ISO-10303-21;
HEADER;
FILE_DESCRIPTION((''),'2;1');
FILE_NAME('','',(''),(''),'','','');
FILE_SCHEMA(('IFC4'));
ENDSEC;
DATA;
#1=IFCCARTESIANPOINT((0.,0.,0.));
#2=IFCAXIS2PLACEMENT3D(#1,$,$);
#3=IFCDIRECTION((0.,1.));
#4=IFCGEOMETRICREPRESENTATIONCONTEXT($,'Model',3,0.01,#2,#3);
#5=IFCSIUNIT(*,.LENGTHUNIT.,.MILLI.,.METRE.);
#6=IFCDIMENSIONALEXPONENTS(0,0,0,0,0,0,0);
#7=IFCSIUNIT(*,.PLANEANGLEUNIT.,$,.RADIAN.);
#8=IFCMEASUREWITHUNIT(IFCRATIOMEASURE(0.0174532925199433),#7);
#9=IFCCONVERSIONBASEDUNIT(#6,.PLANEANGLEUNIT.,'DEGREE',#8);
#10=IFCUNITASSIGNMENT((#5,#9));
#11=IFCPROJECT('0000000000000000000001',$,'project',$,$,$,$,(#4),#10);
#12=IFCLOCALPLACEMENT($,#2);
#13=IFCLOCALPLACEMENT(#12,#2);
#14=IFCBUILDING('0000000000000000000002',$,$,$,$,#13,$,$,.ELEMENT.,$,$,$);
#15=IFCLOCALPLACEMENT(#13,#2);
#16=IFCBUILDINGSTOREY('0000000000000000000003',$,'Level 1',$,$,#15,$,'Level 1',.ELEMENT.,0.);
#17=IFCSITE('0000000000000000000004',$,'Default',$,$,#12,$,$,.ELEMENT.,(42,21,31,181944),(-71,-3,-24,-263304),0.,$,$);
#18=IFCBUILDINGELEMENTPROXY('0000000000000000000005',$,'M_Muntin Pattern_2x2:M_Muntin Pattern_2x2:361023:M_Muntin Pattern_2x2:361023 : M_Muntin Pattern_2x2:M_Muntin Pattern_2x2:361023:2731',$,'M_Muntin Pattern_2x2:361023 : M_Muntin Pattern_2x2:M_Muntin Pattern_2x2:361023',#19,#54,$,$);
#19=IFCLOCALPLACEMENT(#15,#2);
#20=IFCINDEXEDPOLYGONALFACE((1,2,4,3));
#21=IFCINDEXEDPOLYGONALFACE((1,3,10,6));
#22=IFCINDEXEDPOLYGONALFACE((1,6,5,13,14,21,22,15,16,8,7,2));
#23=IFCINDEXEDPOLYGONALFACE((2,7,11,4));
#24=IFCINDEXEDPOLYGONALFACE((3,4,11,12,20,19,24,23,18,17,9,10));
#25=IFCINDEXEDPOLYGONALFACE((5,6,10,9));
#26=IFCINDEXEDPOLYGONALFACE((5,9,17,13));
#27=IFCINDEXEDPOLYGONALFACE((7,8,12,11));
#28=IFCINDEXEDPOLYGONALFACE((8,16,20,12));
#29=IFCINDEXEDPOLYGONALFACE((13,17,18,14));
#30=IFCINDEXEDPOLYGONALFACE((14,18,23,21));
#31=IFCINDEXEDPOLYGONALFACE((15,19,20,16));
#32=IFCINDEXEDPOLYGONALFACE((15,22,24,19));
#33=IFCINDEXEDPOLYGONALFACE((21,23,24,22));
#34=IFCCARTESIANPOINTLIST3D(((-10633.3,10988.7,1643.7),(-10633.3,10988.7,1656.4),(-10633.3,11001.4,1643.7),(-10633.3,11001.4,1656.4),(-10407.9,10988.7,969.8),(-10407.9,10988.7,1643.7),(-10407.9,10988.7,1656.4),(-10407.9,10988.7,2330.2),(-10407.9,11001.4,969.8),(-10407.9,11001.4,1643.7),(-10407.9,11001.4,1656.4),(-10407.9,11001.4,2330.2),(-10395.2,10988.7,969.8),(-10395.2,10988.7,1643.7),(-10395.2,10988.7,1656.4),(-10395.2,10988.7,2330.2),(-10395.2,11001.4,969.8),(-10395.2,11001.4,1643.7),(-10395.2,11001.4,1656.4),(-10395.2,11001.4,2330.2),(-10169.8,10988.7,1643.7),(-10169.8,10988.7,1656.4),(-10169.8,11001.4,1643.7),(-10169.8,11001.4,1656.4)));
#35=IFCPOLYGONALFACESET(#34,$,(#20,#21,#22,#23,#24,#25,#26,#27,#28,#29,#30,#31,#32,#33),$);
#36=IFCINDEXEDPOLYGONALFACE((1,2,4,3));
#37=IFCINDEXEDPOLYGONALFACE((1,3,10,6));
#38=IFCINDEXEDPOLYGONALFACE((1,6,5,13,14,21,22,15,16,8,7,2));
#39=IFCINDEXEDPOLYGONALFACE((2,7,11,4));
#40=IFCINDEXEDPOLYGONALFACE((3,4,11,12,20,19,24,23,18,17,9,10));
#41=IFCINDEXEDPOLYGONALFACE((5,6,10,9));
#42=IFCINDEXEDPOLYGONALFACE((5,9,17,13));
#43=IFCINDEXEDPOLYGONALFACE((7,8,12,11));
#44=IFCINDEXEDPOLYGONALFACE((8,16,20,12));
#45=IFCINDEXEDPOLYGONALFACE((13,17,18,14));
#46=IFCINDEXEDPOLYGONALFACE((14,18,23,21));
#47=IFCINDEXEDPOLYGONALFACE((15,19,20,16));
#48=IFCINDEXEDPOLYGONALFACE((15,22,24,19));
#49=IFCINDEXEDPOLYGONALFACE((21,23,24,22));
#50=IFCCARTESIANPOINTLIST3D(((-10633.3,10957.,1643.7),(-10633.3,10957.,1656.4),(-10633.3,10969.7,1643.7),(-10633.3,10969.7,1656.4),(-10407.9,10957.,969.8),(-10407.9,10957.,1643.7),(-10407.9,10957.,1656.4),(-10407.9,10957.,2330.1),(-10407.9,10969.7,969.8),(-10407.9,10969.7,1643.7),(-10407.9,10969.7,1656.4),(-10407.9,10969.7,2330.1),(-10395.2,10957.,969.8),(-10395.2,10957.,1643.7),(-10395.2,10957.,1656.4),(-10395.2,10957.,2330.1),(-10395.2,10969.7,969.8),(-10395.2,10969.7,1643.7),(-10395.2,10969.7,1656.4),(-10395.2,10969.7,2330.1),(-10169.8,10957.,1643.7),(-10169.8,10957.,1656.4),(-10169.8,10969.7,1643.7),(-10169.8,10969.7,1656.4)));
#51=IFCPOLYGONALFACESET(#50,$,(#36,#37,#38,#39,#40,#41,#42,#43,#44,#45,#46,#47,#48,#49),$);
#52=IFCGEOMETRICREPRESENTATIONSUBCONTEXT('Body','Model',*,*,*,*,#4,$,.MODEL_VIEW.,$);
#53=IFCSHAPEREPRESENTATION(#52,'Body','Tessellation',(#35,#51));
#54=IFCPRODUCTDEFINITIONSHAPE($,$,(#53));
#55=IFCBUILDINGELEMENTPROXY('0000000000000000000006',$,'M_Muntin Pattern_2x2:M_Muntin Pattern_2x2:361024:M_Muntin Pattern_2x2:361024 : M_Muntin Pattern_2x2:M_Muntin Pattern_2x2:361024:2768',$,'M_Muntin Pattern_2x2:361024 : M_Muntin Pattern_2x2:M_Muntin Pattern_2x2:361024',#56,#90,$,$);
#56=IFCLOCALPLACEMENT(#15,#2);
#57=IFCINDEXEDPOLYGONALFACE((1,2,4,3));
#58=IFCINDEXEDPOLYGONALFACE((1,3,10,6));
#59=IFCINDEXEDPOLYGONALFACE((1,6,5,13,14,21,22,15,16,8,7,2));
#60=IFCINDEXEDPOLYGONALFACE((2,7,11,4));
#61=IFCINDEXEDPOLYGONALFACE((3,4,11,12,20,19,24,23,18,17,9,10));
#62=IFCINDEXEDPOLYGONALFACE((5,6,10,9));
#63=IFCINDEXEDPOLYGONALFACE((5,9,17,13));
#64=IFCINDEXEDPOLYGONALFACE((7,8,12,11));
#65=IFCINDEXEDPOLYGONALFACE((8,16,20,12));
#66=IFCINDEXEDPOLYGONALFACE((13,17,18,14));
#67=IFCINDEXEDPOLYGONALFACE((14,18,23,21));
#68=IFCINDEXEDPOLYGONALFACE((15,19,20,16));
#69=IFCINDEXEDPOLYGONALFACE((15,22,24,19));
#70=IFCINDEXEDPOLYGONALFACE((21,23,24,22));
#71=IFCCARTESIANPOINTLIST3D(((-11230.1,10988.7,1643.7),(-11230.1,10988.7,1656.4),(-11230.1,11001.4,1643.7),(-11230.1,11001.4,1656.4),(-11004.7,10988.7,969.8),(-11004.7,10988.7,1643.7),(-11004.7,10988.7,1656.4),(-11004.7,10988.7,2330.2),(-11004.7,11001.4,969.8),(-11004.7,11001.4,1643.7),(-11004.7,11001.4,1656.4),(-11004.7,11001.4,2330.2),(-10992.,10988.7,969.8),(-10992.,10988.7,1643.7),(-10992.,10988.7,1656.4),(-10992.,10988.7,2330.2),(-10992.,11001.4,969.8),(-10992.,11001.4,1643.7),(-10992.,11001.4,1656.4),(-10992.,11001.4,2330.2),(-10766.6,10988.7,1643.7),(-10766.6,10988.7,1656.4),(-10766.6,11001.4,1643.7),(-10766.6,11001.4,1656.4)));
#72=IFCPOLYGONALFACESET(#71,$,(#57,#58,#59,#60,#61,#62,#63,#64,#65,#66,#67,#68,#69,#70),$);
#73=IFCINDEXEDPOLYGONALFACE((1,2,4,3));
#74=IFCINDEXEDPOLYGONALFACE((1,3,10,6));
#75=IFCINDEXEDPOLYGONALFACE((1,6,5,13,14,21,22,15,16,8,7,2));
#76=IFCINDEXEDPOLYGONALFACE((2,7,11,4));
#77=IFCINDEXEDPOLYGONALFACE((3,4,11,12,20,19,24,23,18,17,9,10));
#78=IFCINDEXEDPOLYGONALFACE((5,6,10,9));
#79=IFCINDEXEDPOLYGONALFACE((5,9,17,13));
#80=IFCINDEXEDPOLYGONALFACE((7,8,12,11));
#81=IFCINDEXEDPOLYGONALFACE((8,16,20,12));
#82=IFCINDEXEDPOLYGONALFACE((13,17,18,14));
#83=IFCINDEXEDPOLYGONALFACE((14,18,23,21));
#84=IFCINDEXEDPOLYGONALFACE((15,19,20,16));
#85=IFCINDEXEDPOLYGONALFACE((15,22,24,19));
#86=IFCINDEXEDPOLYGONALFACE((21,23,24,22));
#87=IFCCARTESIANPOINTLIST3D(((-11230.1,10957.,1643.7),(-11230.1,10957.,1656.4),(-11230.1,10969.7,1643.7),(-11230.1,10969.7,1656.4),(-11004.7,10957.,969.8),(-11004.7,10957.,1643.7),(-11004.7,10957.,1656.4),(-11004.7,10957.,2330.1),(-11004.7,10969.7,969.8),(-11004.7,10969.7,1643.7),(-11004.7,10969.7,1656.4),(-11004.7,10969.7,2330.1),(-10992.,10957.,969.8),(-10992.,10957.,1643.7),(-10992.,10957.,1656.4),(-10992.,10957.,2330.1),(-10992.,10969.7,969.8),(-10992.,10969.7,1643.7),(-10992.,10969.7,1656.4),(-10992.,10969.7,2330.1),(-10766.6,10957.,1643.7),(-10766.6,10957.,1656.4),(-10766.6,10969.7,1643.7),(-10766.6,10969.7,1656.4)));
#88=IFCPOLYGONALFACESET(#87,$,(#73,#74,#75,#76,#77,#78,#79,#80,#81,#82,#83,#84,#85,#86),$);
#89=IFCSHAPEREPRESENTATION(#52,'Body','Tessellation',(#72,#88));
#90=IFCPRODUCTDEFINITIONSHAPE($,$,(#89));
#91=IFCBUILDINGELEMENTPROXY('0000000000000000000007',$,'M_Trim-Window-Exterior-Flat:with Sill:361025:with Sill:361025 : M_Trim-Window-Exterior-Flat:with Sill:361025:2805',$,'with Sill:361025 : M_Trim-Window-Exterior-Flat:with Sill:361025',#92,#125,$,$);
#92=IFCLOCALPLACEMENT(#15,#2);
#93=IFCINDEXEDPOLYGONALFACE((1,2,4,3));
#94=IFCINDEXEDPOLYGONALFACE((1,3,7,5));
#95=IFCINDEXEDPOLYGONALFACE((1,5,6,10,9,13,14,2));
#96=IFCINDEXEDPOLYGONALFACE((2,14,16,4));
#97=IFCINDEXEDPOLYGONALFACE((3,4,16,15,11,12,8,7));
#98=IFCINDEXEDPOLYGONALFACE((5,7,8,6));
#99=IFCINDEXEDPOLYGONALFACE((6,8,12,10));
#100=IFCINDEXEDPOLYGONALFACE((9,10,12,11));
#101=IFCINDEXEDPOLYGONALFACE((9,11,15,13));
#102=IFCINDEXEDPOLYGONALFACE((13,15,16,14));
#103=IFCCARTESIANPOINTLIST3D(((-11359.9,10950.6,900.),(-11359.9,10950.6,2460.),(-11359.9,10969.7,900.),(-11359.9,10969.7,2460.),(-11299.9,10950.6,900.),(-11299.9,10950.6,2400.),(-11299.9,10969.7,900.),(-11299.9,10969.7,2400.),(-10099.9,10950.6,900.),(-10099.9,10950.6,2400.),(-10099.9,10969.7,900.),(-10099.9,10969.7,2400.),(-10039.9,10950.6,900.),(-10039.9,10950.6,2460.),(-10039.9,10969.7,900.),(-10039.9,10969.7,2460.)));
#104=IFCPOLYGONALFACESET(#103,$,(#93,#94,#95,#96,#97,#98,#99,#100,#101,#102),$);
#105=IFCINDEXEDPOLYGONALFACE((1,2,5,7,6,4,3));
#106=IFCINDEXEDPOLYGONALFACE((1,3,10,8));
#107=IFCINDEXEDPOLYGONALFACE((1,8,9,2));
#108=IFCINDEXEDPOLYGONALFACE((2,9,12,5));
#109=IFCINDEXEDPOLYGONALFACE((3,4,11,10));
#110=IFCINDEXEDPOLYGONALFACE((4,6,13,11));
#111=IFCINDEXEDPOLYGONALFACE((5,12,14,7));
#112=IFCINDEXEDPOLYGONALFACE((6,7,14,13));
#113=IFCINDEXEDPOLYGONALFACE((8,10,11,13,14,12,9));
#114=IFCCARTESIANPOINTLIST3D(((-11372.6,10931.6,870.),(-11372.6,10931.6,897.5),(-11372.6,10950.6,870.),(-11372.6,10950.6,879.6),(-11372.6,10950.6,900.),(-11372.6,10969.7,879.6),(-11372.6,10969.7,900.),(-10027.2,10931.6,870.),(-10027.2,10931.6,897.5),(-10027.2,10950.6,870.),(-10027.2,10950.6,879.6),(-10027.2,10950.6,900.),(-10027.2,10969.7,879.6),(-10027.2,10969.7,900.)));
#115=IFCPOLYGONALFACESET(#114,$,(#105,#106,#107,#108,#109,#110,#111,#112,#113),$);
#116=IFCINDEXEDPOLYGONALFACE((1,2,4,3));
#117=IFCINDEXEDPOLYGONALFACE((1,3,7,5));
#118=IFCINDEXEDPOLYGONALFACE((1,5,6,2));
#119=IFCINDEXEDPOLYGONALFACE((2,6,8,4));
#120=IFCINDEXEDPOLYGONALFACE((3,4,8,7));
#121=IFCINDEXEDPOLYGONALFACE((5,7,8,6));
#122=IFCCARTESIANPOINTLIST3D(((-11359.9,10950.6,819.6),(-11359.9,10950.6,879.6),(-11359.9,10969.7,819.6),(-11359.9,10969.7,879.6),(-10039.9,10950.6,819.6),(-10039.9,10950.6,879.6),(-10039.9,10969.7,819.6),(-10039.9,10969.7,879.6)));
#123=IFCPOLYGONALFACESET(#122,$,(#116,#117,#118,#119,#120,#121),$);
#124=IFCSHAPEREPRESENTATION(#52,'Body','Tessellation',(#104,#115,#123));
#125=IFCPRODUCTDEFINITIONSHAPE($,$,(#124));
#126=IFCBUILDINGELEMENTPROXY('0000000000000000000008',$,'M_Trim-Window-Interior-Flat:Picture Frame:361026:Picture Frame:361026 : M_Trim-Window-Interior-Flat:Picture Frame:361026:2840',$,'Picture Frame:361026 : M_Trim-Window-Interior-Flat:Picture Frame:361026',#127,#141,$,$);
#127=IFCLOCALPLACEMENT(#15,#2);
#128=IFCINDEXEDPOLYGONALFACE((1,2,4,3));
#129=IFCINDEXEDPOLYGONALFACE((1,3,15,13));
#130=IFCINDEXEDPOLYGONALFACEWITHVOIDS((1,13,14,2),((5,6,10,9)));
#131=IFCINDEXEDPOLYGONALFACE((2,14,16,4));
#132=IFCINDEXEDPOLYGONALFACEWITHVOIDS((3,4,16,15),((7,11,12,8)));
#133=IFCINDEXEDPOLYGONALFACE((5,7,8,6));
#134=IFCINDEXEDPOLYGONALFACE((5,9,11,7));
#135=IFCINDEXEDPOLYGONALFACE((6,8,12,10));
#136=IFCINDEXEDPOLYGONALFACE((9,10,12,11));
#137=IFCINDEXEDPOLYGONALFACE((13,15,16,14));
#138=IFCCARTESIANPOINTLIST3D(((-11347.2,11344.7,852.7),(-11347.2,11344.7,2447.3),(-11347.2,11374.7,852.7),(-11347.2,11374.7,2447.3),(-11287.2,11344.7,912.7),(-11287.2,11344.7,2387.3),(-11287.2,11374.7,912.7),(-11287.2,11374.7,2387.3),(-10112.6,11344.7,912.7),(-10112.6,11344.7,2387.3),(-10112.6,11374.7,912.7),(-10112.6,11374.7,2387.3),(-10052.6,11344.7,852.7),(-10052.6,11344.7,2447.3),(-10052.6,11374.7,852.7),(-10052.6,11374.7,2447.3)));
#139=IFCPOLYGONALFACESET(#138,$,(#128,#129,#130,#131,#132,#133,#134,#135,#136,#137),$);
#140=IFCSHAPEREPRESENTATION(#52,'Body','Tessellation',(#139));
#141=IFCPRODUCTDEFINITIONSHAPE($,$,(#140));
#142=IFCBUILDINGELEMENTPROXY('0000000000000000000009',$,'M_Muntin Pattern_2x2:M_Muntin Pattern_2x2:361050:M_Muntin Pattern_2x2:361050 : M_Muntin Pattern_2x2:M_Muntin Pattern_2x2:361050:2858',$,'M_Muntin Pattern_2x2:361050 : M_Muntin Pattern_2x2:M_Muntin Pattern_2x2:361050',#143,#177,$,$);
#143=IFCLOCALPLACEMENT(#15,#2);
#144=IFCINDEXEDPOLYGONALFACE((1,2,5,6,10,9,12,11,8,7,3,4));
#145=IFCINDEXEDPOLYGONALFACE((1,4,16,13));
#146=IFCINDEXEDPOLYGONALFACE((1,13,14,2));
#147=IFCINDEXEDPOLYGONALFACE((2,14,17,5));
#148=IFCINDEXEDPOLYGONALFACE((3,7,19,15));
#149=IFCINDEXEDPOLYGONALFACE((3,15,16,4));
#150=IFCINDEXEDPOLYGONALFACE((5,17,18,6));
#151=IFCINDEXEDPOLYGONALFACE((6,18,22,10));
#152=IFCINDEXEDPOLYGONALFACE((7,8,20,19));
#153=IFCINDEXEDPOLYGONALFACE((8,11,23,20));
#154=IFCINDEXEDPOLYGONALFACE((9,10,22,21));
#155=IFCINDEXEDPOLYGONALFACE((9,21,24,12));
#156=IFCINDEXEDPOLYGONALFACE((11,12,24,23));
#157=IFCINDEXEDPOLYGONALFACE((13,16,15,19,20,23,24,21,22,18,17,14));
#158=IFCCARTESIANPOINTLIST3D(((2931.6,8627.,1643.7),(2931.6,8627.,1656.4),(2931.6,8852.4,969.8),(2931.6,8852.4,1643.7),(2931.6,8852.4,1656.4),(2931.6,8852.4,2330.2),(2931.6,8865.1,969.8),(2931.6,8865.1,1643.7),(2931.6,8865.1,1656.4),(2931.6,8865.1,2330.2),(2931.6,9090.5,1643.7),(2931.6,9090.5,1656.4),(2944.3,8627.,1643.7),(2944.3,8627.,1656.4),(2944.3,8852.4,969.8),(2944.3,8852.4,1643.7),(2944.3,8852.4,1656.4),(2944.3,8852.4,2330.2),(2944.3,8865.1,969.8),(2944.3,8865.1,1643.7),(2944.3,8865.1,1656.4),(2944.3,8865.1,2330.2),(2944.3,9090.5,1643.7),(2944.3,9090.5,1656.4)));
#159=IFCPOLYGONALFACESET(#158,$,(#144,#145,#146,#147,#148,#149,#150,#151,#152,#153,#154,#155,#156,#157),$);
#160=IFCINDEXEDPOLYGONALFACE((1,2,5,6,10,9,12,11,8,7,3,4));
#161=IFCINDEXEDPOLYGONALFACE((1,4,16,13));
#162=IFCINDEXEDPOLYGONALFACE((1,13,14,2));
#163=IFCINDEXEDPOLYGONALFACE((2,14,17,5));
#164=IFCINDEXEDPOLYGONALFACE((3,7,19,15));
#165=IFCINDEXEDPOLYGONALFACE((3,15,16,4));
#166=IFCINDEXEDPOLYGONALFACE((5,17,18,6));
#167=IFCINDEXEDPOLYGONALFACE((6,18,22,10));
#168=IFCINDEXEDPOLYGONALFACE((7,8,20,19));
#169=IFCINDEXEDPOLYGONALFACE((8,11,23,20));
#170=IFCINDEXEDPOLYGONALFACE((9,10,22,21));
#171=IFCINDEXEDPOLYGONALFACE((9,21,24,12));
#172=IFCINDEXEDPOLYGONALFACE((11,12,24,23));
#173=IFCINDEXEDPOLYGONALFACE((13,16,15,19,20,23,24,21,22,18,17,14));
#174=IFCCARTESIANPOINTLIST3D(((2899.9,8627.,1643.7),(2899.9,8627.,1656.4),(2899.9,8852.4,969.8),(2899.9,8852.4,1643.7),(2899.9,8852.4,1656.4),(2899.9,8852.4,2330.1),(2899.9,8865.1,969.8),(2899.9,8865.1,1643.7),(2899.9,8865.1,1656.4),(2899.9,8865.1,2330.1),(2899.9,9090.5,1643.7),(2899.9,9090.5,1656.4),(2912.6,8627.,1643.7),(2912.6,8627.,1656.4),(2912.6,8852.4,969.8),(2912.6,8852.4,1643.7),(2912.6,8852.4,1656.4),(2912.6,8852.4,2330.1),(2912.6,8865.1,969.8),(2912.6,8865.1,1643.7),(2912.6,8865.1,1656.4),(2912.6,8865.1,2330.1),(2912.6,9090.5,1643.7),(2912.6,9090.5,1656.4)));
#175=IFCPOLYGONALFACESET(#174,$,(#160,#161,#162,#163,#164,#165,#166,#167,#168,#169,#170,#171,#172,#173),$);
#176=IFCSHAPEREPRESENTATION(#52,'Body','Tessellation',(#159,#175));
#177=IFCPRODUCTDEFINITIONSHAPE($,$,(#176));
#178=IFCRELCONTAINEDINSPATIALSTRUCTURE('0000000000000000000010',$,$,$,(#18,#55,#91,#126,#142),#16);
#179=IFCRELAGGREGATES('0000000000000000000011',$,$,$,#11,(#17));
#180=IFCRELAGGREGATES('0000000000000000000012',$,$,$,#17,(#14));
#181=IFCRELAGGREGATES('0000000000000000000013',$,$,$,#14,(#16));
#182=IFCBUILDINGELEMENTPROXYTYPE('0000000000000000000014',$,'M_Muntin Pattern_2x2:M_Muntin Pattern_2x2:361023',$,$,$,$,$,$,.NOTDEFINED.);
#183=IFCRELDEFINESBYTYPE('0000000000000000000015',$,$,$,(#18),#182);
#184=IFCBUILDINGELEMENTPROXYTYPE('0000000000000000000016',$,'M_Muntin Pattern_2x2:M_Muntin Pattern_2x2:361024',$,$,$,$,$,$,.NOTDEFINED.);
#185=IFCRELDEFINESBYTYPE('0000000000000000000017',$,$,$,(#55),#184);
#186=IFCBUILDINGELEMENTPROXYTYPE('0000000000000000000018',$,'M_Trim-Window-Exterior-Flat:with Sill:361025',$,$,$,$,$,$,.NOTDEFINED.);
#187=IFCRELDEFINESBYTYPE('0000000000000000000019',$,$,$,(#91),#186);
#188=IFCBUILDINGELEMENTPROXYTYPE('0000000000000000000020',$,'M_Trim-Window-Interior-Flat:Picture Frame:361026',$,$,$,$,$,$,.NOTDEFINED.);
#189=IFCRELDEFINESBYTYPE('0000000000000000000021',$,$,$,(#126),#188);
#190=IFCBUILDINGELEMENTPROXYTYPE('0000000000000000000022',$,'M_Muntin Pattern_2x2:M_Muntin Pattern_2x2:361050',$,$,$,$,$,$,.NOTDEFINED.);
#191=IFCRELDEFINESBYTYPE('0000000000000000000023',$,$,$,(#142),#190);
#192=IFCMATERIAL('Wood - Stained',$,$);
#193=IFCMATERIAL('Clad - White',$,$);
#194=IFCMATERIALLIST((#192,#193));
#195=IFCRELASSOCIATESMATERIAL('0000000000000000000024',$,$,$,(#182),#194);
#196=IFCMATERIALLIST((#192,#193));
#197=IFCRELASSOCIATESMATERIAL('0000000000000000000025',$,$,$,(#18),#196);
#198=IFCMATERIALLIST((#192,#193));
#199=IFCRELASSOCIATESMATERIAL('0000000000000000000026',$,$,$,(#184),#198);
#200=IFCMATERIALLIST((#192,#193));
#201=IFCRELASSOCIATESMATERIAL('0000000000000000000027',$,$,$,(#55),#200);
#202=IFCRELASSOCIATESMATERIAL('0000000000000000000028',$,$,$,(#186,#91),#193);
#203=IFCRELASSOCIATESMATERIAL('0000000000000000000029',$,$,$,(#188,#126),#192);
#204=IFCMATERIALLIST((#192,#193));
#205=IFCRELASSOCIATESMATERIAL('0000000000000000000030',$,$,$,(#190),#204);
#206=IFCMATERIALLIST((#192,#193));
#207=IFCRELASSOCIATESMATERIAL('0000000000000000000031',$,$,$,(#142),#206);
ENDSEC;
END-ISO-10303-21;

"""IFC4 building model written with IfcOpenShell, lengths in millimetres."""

from ifc_helpers import new_model, entity, si_unit, converted_unit, direction, frame, frame_2d, origin, place, context, subcontext, project, spatial, polyline, rectangle, outline, extrude, source, transform, mapped, material, material_list, type_object, type_shapes, element, save


model = new_model("IFC4")

# Units and contexts
model_context = context("Model", 3, precision=0.01, world=origin(), true_north=direction((0.0, 1.0)))
body_context = subcontext(model_context, "Body", "Model", "MODEL_VIEW")
ifc_project = project(units=[si_unit("LENGTHUNIT", "METRE", prefix="MILLI"), converted_unit("PLANEANGLEUNIT", "DEGREE", entity("IfcRatioMeasure", 0.0174532925199433), si_unit("PLANEANGLEUNIT", "RADIAN"), dimensions=[0, 0, 0, 0, 0, 0, 0])], contexts=[model_context])

# Site, building, storey
site_placement = place(None, origin())
site = spatial("IfcSite", under=ifc_project, at=site_placement, Name="Default", CompositionType="ELEMENT", RefLatitude=(42, 21, 31, 181944), RefLongitude=(-71, -3, -24, -263304), RefElevation=0.0)
building_placement = place(site_placement, origin())
building = spatial("IfcBuilding", under=site, at=building_placement, CompositionType="ELEMENT")
storey_placement = place(building_placement, origin())
storey = spatial("IfcBuildingStorey", under=building, at=storey_placement, Name="Level 1", LongName="Level 1", CompositionType="ELEMENT", Elevation=0.0)

# Building element proxies
ifc_material_1 = material(Name="Wood - Stained")
ifc_material_2 = material(Name="Clad - White")
ifc_material_list_1 = material_list([ifc_material_1, ifc_material_2])
ifc_material_list_2 = material_list([ifc_material_1, ifc_material_2])
building_element_proxy_type_1 = type_object("IfcBuildingElementProxyType", Name="M_Muntin Pattern_2x2:M_Muntin Pattern_2x2:361023", PredefinedType="NOTDEFINED", material=ifc_material_list_2)
shared_shape_1 = source(origin(), body_context, "Body", "SweptSolid", [
    extrude(outline(polyline([(-680.2, 6.4), (-680.2, -6.3), (-6.4, -6.3), (-6.4, -231.7), (6.3, -231.7), (6.3, -6.3), (680.2, -6.3), (680.2, 6.4), (6.3, 6.4), (6.3, 231.7), (-6.4, 231.7), (-6.4, 6.4), (-680.2, 6.4)])), frame((-10401.5, 10988.7, 1650.0), z_axis=(0.0, -1.0, 0.0), x_axis=(0.0, 0.0, -1.0)), (0.0, 0.0, -1.0), 12.7),
    extrude(outline(polyline([(-680.1, 6.4), (-680.1, -6.3), (-6.4, -6.3), (-6.4, -231.7), (6.3, -231.7), (6.3, -6.3), (680.2, -6.3), (680.2, 6.4), (6.3, 6.4), (6.3, 231.7), (-6.4, 231.7), (-6.4, 6.4), (-680.1, 6.4)])), frame((-10401.5, 10957.0, 1650.0), z_axis=(0.0, -1.0, 0.0), x_axis=(0.0, 0.0, -1.0)), (0.0, 0.0, -1.0), 12.7),
])
type_shapes(building_element_proxy_type_1, [shared_shape_1])
proxy_1_placement = place(storey_placement, origin())
element("IfcBuildingElementProxy", 1, at=proxy_1_placement, inside=storey, type_object=building_element_proxy_type_1, material=ifc_material_list_1, Name="M_Muntin Pattern_2x2:M_Muntin Pattern_2x2:361023:M_Muntin Pattern_2x2:361023 : M_Muntin Pattern_2x2:M_Muntin Pattern_2x2:361023:2731", ObjectType="M_Muntin Pattern_2x2:361023 : M_Muntin Pattern_2x2:M_Muntin Pattern_2x2:361023", context=body_context, shape_type="MappedRepresentation", body=[
    mapped(shared_shape_1, transform((0.0, 0.0, 0.0), scale=1.0)),
])
ifc_material_list_3 = material_list([ifc_material_1, ifc_material_2])
ifc_material_list_4 = material_list([ifc_material_1, ifc_material_2])
building_element_proxy_type_2 = type_object("IfcBuildingElementProxyType", Name="M_Muntin Pattern_2x2:M_Muntin Pattern_2x2:361024", PredefinedType="NOTDEFINED", material=ifc_material_list_4)
shared_shape_2 = source(origin(), body_context, "Body", "SweptSolid", [
    extrude(outline(polyline([(-6.4, -680.1), (6.3, -680.1), (6.3, -6.4), (231.7, -6.4), (231.7, 6.3), (6.3, 6.3), (6.3, 680.2), (-6.4, 680.2), (-6.4, 6.3), (-231.7, 6.3), (-231.7, -6.4), (-6.4, -6.4), (-6.4, -680.1)])), frame((-10998.4, 10988.7, 1650.0), z_axis=(0.0, 1.0, 0.0), x_axis=(1.0, 0.0, 0.0)), (0.0, 0.0, 1.0), 12.7),
    extrude(outline(polyline([(-6.4, -680.1), (6.3, -680.1), (6.3, -6.4), (231.7, -6.4), (231.7, 6.3), (6.3, 6.3), (6.3, 680.2), (-6.4, 680.2), (-6.4, 6.3), (-231.7, 6.3), (-231.7, -6.4), (-6.4, -6.4), (-6.4, -680.1)])), frame((-10998.4, 10957.0, 1650.0), z_axis=(0.0, 1.0, 0.0), x_axis=(1.0, 0.0, 0.0)), (0.0, 0.0, 1.0), 12.7),
])
type_shapes(building_element_proxy_type_2, [shared_shape_2])
proxy_2_placement = place(storey_placement, origin())
element("IfcBuildingElementProxy", 2, at=proxy_2_placement, inside=storey, type_object=building_element_proxy_type_2, material=ifc_material_list_3, Name="M_Muntin Pattern_2x2:M_Muntin Pattern_2x2:361024:M_Muntin Pattern_2x2:361024 : M_Muntin Pattern_2x2:M_Muntin Pattern_2x2:361024:2768", ObjectType="M_Muntin Pattern_2x2:361024 : M_Muntin Pattern_2x2:M_Muntin Pattern_2x2:361024", context=body_context, shape_type="MappedRepresentation", body=[
    mapped(shared_shape_2, transform((0.0, 0.0, 0.0), scale=1.0)),
])
building_element_proxy_type_3 = type_object("IfcBuildingElementProxyType", Name="M_Trim-Window-Exterior-Flat:with Sill:361025", PredefinedType="NOTDEFINED", material=ifc_material_2)
shared_shape_3 = source(origin(), body_context, "Body", "SweptSolid", [
    extrude(outline(polyline([(-765.0, -660.0), (795.0, -660.0), (795.0, 660.0), (-765.0, 660.0), (-765.0, 600.0), (735.0, 600.0), (735.0, -600.0), (-765.0, -600.0), (-765.0, -660.0)])), frame((-10699.9, 10950.6, 1665.0), z_axis=(0.0, 1.0, 0.0), x_axis=(0.0, 0.0, 1.0)), (0.0, 0.0, 1.0), 19.1),
    extrude(outline(polyline([(-15.2, 0.0), (-15.2, -19.0), (12.3, -19.0), (14.8, 0.0), (14.8, 19.0), (-5.7, 19.0), (-5.7, 0.0), (-15.2, 0.0)])), frame((-11372.6, 10950.6, 885.2), z_axis=(-1.0, 0.0, 0.0), x_axis=(0.0, 0.0, 1.0)), (0.0, 0.0, -1.0), 1345.4),
    extrude(rectangle(XDim=19.1, YDim=1320.0, at=frame_2d((0.0, 0.0), x_axis=(1.0, 0.0))), frame((-10699.9, 10960.1, 819.6), z_axis=(0.0, 0.0, 1.0), x_axis=(0.0, 1.0, 0.0)), (0.0, 0.0, 1.0), 60.0),
])
type_shapes(building_element_proxy_type_3, [shared_shape_3])
proxy_3_placement = place(storey_placement, origin())
element("IfcBuildingElementProxy", 3, at=proxy_3_placement, inside=storey, type_object=building_element_proxy_type_3, material=ifc_material_2, Name="M_Trim-Window-Exterior-Flat:with Sill:361025:with Sill:361025 : M_Trim-Window-Exterior-Flat:with Sill:361025:2805", ObjectType="with Sill:361025 : M_Trim-Window-Exterior-Flat:with Sill:361025", context=body_context, shape_type="MappedRepresentation", body=[
    mapped(shared_shape_3, transform((0.0, 0.0, 0.0), scale=1.0)),
])
building_element_proxy_type_4 = type_object("IfcBuildingElementProxyType", Name="M_Trim-Window-Interior-Flat:Picture Frame:361026", PredefinedType="NOTDEFINED", material=ifc_material_1)
shared_shape_4 = source(origin(), body_context, "Body", "SweptSolid", [
    extrude(outline(polyline([(-797.3, -647.3), (797.3, -647.3), (797.3, 647.3), (-797.3, 647.3), (-797.3, -647.3)]), holes=[polyline([(737.3, 587.3), (737.3, -587.3), (-737.3, -587.3), (-737.3, 587.3), (737.3, 587.3)])]), frame((-10699.9, 11344.7, 1650.0), z_axis=(0.0, 1.0, 0.0), x_axis=(0.0, 0.0, -1.0)), (0.0, 0.0, 1.0), 30.0),
])
type_shapes(building_element_proxy_type_4, [shared_shape_4])
proxy_4_placement = place(storey_placement, origin())
element("IfcBuildingElementProxy", 4, at=proxy_4_placement, inside=storey, type_object=building_element_proxy_type_4, material=ifc_material_1, Name="M_Trim-Window-Interior-Flat:Picture Frame:361026:Picture Frame:361026 : M_Trim-Window-Interior-Flat:Picture Frame:361026:2840", ObjectType="Picture Frame:361026 : M_Trim-Window-Interior-Flat:Picture Frame:361026", context=body_context, shape_type="MappedRepresentation", body=[
    mapped(shared_shape_4, transform((0.0, 0.0, 0.0), scale=1.0)),
])
ifc_material_list_5 = material_list([ifc_material_1, ifc_material_2])
ifc_material_list_6 = material_list([ifc_material_1, ifc_material_2])
building_element_proxy_type_5 = type_object("IfcBuildingElementProxyType", Name="M_Muntin Pattern_2x2:M_Muntin Pattern_2x2:361050", PredefinedType="NOTDEFINED", material=ifc_material_list_6)
shared_shape_5 = source(origin(), body_context, "Body", "SweptSolid", [
    extrude(outline(polyline([(-680.2, 6.4), (-680.2, -6.3), (-6.4, -6.3), (-6.4, -231.7), (6.3, -231.7), (6.3, -6.3), (680.2, -6.3), (680.2, 6.4), (6.3, 6.4), (6.3, 231.7), (-6.4, 231.7), (-6.4, 6.4), (-680.2, 6.4)])), frame((2931.6, 8858.7, 1650.0), z_axis=(-1.0, 0.0, 0.0), x_axis=(0.0, 0.0, -1.0)), (0.0, 0.0, -1.0), 12.7),
    extrude(outline(polyline([(-680.1, 6.4), (-680.1, -6.3), (-6.4, -6.3), (-6.4, -231.7), (6.3, -231.7), (6.3, -6.3), (680.2, -6.3), (680.2, 6.4), (6.3, 6.4), (6.3, 231.7), (-6.4, 231.7), (-6.4, 6.4), (-680.1, 6.4)])), frame((2899.9, 8858.7, 1650.0), z_axis=(-1.0, 0.0, 0.0), x_axis=(0.0, 0.0, -1.0)), (0.0, 0.0, -1.0), 12.7),
])
type_shapes(building_element_proxy_type_5, [shared_shape_5])
proxy_5_placement = place(storey_placement, origin())
element("IfcBuildingElementProxy", 5, at=proxy_5_placement, inside=storey, type_object=building_element_proxy_type_5, material=ifc_material_list_5, Name="M_Muntin Pattern_2x2:M_Muntin Pattern_2x2:361050:M_Muntin Pattern_2x2:361050 : M_Muntin Pattern_2x2:M_Muntin Pattern_2x2:361050:2858", ObjectType="M_Muntin Pattern_2x2:361050 : M_Muntin Pattern_2x2:M_Muntin Pattern_2x2:361050", context=body_context, shape_type="MappedRepresentation", body=[
    mapped(shared_shape_5, transform((0.0, 0.0, 0.0), scale=1.0)),
])

save(model, "model.ifc")
